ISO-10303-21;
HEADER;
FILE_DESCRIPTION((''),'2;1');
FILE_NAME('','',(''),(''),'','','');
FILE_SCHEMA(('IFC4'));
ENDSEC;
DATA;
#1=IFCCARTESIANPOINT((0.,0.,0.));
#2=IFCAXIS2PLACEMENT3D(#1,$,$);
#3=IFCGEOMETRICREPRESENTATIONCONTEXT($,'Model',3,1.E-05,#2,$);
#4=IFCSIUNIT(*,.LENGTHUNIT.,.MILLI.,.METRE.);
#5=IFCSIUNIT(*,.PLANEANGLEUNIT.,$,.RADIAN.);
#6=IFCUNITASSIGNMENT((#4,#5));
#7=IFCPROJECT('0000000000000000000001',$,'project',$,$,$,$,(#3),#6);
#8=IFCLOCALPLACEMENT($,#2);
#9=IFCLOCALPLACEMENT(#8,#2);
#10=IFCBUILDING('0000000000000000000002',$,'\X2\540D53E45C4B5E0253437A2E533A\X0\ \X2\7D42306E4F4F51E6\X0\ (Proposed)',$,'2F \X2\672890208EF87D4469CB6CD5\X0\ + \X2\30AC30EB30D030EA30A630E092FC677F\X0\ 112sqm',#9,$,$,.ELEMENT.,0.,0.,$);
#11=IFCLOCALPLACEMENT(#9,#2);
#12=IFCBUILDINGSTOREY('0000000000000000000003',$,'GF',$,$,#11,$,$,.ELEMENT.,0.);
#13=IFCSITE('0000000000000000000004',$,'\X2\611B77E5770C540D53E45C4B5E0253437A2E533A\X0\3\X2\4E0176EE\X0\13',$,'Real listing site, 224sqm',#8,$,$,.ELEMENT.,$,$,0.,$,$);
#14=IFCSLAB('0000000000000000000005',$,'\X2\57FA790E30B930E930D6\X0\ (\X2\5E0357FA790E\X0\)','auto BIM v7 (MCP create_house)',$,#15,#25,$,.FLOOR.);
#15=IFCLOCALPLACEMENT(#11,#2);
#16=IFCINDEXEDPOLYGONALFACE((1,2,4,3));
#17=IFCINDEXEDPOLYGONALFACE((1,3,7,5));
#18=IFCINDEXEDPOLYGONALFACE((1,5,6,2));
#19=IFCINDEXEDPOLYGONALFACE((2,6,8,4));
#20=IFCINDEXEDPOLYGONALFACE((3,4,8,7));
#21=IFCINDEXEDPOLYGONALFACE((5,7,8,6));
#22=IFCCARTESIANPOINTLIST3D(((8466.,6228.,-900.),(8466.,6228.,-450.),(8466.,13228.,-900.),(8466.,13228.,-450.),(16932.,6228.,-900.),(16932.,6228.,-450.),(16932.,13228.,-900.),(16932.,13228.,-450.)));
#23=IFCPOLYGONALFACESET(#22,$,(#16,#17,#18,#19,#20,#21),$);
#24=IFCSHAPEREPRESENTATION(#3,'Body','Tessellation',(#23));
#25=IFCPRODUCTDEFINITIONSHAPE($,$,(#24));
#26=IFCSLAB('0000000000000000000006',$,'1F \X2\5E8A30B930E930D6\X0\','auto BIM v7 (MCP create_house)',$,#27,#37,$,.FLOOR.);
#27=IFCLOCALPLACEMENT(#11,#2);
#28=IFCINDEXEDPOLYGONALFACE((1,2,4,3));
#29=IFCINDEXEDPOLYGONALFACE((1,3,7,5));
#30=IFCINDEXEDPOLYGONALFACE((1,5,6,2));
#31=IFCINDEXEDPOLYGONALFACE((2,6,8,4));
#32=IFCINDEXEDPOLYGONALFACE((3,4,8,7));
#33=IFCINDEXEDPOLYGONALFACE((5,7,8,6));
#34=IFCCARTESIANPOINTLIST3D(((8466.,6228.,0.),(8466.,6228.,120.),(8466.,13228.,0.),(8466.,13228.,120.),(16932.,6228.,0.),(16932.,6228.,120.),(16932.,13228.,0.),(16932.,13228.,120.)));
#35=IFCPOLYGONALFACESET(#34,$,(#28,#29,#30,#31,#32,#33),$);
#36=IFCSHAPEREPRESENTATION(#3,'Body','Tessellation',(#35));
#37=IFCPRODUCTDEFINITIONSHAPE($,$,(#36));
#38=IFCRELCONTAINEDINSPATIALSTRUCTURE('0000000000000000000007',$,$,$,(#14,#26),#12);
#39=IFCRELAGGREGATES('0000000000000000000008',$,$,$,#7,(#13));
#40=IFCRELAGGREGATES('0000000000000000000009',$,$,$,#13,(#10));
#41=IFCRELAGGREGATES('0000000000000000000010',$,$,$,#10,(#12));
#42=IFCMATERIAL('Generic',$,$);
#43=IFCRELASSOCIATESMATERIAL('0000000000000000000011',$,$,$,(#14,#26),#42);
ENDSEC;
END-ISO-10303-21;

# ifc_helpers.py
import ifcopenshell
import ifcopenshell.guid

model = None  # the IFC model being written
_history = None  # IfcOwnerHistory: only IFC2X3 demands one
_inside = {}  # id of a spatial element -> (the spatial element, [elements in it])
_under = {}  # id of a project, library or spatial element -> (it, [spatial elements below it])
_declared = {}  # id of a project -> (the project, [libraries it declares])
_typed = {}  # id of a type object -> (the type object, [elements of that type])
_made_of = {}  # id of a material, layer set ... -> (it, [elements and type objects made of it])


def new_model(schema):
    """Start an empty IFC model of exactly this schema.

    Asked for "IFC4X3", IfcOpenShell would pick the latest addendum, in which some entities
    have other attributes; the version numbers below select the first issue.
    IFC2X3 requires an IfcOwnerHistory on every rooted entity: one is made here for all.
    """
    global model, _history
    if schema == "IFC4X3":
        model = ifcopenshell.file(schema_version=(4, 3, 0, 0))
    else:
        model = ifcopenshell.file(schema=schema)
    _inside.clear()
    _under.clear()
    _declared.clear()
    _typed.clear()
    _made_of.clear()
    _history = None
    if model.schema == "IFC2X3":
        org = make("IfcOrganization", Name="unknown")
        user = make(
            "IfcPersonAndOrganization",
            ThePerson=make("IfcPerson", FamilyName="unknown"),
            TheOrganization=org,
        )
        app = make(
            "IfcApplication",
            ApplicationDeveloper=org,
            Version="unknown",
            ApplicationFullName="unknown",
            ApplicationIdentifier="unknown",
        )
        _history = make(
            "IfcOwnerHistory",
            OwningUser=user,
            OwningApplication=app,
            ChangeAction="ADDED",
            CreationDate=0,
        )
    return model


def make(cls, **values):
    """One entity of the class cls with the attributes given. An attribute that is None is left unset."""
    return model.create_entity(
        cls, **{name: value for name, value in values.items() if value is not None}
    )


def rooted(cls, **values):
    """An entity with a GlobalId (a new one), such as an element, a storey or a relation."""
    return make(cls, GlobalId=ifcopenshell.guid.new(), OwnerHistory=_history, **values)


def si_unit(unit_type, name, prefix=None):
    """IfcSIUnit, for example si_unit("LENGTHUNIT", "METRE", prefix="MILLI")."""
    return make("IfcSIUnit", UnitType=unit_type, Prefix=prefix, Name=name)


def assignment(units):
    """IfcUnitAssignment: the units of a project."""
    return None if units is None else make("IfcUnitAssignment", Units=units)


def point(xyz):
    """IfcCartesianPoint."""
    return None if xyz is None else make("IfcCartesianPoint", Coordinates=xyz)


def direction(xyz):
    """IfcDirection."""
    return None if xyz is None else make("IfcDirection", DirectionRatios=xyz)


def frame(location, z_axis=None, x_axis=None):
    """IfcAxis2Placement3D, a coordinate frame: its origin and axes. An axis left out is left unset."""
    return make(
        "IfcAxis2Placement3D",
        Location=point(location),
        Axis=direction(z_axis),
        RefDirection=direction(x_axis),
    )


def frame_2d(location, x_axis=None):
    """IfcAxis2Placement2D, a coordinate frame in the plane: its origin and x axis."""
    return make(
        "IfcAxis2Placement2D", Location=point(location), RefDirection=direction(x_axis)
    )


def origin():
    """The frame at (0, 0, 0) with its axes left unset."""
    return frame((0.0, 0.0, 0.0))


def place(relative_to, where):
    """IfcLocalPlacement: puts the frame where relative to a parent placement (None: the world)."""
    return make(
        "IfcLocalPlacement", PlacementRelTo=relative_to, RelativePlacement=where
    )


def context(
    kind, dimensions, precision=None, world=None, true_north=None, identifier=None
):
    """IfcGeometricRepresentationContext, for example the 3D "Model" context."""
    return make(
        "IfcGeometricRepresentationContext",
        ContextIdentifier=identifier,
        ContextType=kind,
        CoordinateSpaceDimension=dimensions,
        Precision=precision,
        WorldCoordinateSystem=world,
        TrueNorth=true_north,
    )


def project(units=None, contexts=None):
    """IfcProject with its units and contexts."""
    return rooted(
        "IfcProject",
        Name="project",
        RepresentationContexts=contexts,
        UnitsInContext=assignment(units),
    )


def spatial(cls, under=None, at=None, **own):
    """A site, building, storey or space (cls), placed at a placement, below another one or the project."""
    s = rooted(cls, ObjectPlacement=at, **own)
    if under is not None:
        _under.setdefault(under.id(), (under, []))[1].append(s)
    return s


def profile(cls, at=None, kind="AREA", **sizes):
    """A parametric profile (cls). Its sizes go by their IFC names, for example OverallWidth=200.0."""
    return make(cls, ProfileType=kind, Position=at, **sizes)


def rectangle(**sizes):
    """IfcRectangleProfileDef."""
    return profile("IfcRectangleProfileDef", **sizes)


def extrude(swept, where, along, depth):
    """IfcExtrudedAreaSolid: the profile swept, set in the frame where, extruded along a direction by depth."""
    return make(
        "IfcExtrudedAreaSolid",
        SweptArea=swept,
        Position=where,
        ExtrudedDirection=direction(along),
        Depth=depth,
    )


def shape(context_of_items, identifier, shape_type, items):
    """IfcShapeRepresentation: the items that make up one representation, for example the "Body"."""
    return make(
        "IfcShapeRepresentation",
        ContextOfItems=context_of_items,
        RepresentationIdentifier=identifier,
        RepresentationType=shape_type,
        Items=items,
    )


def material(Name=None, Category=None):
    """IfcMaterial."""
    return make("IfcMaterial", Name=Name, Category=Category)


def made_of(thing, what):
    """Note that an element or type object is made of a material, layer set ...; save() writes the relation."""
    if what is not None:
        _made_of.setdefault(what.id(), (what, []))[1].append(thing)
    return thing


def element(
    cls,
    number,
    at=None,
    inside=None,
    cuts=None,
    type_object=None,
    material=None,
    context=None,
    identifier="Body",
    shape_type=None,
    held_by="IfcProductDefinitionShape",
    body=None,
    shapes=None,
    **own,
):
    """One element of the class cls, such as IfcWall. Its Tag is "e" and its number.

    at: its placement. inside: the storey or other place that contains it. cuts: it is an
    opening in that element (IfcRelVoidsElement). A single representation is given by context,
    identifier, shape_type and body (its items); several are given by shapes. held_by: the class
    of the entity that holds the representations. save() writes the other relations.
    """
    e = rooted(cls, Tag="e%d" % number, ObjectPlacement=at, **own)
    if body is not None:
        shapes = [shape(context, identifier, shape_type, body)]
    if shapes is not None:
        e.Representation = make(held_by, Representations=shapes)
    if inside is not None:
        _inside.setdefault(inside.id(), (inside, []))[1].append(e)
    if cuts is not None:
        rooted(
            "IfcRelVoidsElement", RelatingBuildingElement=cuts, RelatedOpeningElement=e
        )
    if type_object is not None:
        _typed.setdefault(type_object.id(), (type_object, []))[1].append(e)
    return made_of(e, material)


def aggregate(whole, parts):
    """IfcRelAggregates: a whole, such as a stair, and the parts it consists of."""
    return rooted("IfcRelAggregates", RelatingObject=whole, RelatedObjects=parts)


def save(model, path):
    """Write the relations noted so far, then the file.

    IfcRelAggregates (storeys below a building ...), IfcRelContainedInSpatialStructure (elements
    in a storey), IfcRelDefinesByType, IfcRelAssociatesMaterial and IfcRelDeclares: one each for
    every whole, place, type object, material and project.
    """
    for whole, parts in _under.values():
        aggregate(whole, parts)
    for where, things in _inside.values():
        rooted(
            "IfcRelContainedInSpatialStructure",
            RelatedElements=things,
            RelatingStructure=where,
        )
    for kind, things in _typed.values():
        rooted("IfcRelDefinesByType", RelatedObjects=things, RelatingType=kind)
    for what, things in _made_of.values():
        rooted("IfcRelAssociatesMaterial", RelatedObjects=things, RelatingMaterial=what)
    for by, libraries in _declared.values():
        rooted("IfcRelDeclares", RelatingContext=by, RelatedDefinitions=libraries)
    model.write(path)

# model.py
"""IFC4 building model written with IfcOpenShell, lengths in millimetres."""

from ifc_helpers import new_model, si_unit, frame, frame_2d, origin, place, context, project, spatial, rectangle, extrude, material, element, save


model = new_model("IFC4")

# Units and contexts
model_context = context("Model", 3, precision=1e-05, world=origin())
ifc_project = project(units=[si_unit("LENGTHUNIT", "METRE", prefix="MILLI"), si_unit("PLANEANGLEUNIT", "RADIAN")], contexts=[model_context])

# Site, building, storey
site_placement = place(None, origin())
site = spatial("IfcSite", under=ifc_project, at=site_placement, Name="愛知県名古屋市千種区3丁目13", ObjectType="Real listing site, 224sqm", CompositionType="ELEMENT", RefElevation=0.0)
building_placement = place(site_placement, origin())
building = spatial("IfcBuilding", under=site, at=building_placement, Name="名古屋市千種区 終の住処 (Proposed)", ObjectType="2F 木造軸組構法 + ガルバリウム鋼板 112sqm", CompositionType="ELEMENT", ElevationOfRefHeight=0.0, ElevationOfTerrain=0.0)
storey_placement = place(building_placement, origin())
storey = spatial("IfcBuildingStorey", under=building, at=storey_placement, Name="GF", CompositionType="ELEMENT", Elevation=0.0)

# Slabs
ifc_material = material(Name="Generic")
slab_1_placement = place(storey_placement, frame((4233.0, 3114.0, -450.0)))
element("IfcSlab", 1, at=slab_1_placement, inside=storey, material=ifc_material, Name="基礎スラブ (布基礎)", Description="auto BIM v7 (MCP create_house)", PredefinedType="FLOOR", context=model_context, shape_type="SweptSolid", body=[
    extrude(rectangle(XDim=8466.0, YDim=7000.0, at=frame_2d((4233.0, 3500.0))), frame((4233.0, 3114.0, -450.0)), (0.0, 0.0, 1.0), 450.0),
])
slab_2_placement = place(storey_placement, frame((4233.0, 3114.0, 0.0)))
element("IfcSlab", 2, at=slab_2_placement, inside=storey, material=ifc_material, Name="1F 床スラブ", Description="auto BIM v7 (MCP create_house)", PredefinedType="FLOOR", context=model_context, shape_type="SweptSolid", body=[
    extrude(rectangle(XDim=8466.0, YDim=7000.0, at=frame_2d((4233.0, 3500.0))), frame((4233.0, 3114.0, 0.0)), (0.0, 0.0, 1.0), 120.0),
])

save(model, "model.ifc")
